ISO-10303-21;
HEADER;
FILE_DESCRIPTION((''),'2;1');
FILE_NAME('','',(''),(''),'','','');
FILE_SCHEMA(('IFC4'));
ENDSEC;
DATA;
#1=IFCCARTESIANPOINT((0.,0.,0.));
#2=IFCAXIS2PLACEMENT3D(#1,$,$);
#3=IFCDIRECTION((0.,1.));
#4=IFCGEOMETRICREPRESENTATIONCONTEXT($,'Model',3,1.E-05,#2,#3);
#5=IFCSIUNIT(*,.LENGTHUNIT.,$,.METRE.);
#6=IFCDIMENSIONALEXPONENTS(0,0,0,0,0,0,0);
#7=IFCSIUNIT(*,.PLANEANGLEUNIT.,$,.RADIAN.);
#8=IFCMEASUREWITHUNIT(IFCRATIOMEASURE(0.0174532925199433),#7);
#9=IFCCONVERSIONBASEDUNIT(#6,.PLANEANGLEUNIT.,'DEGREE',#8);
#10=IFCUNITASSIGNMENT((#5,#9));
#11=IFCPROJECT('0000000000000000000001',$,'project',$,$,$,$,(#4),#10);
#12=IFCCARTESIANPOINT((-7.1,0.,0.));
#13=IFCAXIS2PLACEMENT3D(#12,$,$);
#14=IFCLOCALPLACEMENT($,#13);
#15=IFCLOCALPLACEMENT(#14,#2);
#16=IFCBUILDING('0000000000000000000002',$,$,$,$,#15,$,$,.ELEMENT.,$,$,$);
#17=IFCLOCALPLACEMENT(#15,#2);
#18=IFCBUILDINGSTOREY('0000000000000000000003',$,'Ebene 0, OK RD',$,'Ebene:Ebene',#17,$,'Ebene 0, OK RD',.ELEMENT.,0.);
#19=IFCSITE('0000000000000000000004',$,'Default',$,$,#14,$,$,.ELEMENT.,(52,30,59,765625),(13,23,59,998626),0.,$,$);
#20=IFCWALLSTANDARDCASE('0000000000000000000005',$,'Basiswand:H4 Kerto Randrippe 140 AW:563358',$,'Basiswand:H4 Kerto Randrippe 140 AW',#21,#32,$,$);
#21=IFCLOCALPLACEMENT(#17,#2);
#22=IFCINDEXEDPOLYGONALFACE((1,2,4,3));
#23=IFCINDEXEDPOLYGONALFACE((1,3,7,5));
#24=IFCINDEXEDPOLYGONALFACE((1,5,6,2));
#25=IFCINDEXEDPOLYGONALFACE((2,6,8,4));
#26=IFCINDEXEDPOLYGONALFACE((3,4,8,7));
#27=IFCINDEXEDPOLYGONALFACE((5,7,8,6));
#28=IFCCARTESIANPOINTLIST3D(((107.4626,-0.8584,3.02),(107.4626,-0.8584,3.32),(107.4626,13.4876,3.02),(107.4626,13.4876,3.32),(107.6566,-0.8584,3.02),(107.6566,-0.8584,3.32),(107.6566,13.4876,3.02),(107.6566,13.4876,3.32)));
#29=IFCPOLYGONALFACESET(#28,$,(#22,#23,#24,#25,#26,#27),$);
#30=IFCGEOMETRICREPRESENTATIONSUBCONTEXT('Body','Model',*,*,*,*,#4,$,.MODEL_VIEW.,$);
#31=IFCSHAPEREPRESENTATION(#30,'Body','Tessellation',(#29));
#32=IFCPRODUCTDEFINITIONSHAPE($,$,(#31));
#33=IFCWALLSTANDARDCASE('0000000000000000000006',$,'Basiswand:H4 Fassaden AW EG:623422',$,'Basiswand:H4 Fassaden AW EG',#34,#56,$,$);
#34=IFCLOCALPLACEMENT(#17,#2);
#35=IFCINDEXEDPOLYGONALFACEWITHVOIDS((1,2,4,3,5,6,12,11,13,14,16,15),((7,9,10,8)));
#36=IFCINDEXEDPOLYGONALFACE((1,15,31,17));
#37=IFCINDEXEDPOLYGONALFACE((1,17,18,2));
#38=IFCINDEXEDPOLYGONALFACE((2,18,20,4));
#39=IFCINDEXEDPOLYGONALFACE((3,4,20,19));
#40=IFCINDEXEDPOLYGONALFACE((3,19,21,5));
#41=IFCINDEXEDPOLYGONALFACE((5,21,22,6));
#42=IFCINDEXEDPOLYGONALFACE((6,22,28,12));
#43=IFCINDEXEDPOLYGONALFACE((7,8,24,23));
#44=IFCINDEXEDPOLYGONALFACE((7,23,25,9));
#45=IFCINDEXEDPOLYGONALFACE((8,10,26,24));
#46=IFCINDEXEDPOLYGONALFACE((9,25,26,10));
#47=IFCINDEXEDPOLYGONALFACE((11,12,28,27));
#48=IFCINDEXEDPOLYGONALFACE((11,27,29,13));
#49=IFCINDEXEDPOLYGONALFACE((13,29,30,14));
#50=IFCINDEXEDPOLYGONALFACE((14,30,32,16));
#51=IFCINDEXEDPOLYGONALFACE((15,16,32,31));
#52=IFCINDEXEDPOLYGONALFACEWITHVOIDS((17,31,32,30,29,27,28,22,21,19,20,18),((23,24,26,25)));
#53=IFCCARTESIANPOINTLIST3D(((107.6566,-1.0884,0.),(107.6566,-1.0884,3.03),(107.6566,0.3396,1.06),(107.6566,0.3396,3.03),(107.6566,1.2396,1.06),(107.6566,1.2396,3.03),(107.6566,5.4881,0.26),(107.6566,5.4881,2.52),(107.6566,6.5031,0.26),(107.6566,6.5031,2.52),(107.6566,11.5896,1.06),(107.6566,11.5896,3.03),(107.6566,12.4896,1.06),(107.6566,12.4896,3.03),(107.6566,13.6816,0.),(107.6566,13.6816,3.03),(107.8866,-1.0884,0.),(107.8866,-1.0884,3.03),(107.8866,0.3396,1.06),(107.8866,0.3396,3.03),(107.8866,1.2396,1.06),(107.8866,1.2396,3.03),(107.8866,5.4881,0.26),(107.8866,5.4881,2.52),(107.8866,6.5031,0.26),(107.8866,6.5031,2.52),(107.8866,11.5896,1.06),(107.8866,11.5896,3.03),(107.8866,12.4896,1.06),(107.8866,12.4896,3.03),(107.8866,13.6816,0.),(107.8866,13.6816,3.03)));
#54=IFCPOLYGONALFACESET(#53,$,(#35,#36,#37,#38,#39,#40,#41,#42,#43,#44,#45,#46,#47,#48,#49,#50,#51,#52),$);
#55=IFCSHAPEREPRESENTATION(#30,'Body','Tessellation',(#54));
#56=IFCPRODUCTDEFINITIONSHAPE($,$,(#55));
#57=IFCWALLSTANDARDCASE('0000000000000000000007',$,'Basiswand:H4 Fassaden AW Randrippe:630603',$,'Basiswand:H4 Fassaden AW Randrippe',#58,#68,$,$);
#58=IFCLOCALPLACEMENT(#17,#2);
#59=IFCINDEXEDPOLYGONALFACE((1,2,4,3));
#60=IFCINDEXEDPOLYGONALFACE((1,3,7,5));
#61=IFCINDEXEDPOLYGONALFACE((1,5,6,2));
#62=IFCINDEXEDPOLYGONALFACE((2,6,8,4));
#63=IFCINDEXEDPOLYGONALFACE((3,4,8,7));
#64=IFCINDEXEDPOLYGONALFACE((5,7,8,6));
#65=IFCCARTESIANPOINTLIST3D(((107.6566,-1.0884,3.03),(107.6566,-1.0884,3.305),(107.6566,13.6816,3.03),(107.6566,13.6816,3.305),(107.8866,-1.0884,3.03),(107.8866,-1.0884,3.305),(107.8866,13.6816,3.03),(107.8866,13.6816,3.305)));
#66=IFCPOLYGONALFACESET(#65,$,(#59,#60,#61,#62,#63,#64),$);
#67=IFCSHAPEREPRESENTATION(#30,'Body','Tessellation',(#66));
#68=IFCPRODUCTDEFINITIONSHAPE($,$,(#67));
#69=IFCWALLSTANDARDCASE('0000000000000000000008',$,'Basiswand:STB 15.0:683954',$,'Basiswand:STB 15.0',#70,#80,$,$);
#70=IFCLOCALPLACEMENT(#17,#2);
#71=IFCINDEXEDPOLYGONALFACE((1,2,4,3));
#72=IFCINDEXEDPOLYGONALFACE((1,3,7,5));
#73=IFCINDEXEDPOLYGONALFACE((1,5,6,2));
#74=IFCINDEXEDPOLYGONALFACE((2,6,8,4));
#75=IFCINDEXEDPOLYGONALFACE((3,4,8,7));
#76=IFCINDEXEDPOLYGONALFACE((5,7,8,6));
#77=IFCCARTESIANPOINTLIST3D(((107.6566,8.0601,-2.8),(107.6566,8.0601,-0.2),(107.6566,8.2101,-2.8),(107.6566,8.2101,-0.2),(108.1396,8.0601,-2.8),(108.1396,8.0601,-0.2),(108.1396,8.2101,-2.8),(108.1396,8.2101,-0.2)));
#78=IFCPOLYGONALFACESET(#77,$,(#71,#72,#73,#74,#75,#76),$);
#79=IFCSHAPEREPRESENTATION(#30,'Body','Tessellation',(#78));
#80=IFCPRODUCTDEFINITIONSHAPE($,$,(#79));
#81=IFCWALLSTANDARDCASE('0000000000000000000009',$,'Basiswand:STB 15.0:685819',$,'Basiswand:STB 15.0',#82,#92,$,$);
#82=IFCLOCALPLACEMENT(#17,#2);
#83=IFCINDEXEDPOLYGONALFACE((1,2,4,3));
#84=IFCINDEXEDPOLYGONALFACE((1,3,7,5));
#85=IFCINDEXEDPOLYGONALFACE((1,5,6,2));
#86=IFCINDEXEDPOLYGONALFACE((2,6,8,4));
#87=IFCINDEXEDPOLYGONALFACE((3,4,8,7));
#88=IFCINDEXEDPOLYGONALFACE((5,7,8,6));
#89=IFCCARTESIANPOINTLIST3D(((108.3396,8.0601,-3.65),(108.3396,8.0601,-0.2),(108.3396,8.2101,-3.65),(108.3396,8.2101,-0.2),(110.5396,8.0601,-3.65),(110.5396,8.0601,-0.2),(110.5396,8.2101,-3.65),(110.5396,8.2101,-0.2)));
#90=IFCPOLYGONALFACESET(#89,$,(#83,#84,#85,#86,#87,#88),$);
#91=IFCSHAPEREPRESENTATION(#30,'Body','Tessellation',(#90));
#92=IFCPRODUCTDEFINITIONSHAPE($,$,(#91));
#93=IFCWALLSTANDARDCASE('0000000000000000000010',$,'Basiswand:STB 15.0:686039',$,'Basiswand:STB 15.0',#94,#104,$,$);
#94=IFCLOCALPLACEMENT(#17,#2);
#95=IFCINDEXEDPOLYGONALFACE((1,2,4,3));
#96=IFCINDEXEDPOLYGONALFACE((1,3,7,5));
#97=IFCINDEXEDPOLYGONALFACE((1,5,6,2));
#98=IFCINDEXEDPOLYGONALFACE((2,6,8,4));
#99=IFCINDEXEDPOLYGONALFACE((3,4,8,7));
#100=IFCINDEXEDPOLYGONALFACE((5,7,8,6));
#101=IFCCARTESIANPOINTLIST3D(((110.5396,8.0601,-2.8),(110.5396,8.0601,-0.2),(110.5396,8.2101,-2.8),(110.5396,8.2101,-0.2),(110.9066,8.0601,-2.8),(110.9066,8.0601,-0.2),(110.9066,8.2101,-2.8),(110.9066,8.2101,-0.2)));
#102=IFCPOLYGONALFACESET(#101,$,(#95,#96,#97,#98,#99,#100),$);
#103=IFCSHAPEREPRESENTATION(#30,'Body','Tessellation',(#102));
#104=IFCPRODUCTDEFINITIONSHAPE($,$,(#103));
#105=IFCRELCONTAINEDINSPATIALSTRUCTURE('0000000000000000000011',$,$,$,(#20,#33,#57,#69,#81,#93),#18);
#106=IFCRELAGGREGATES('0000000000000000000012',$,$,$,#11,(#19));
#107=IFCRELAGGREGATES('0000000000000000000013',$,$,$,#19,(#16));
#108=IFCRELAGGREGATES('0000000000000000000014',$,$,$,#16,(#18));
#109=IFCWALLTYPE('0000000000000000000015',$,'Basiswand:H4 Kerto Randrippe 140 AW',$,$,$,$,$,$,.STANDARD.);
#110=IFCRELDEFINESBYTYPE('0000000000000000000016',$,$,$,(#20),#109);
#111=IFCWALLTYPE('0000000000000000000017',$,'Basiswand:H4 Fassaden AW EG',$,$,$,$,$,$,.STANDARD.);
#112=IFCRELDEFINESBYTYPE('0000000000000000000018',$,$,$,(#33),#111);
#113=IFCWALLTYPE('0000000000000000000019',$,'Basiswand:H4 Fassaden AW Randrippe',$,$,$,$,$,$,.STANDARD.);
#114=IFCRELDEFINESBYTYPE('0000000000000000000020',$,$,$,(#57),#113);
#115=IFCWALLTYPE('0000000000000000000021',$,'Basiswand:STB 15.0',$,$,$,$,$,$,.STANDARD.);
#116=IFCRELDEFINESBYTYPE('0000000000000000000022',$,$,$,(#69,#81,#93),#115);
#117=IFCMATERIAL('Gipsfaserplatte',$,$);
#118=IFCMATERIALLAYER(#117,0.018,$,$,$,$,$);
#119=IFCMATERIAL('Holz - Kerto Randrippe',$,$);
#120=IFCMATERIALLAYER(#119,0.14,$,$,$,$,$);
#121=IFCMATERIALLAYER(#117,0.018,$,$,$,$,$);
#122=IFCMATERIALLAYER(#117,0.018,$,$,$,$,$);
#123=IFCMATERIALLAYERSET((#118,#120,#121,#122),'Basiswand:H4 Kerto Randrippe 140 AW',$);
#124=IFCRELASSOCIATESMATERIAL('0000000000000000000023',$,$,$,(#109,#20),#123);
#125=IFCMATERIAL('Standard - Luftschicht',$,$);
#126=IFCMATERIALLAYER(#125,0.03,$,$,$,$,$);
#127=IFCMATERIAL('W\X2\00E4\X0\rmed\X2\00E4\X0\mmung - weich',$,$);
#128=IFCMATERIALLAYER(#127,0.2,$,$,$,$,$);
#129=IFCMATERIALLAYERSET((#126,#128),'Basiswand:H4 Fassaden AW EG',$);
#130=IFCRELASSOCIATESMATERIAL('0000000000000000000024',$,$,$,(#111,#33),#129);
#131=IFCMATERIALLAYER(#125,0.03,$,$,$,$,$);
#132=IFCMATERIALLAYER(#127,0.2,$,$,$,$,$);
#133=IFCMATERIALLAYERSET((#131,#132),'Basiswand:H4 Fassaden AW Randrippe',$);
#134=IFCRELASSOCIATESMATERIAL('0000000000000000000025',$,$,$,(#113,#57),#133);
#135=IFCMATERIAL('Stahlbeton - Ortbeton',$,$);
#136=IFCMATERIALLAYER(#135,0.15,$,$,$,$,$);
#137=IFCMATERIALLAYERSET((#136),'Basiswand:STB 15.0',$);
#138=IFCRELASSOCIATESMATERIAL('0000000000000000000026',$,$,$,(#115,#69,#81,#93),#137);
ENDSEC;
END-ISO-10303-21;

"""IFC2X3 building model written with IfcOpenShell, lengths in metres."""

from ifc_helpers import new_model, entity, si_unit, converted_unit, direction, frame, frame_2d, origin, place, context, subcontext, project, spatial, rectangle, extrude, material, layer, layer_set, layer_usage, type_object, element, save


model = new_model("IFC2X3")

# Units and contexts
model_context = context("Model", 3, precision=1e-05, world=origin(), true_north=direction((0.0, 1.0)))
body_context = subcontext(model_context, "Body", "Model", "MODEL_VIEW")
ifc_project = project(units=[si_unit("LENGTHUNIT", "METRE"), converted_unit("PLANEANGLEUNIT", "DEGREE", entity("IfcRatioMeasure", 0.0174532925199433), si_unit("PLANEANGLEUNIT", "RADIAN"), dimensions=[0, 0, 0, 0, 0, 0, 0])], contexts=[model_context])

# Site, building, storey
site_placement = place(None, frame((-7.1, 0.0, 0.0)))
site = spatial("IfcSite", under=ifc_project, at=site_placement, Name="Default", CompositionType="ELEMENT", RefLatitude=(52, 30, 59, 765625), RefLongitude=(13, 23, 59, 998626), RefElevation=0.0)
building_placement = place(site_placement, origin())
building = spatial("IfcBuilding", under=site, at=building_placement, CompositionType="ELEMENT")
storey_placement = place(building_placement, origin())
storey = spatial("IfcBuildingStorey", under=building, at=storey_placement, Name="Ebene 0, OK RD", ObjectType="Ebene:Ebene", LongName="Ebene 0, OK RD", CompositionType="ELEMENT", Elevation=0.0)

# Shared definitions
ifc_material_1 = material(Name="Gipsfaserplatte")

# Shared definitions
ifc_material_2 = material(Name="Stahlbeton - Ortbeton")

# Wall
ifc_layer_1 = layer(ifc_material_1, 0.018)
ifc_material_3 = material(Name="Holz - Kerto Randrippe")
ifc_layer_2 = layer(ifc_material_3, 0.14)
ifc_layer_3 = layer(ifc_material_1, 0.018)
ifc_layer_4 = layer(ifc_material_1, 0.018)
ifc_layer_set_1 = layer_set([ifc_layer_1, ifc_layer_2, ifc_layer_3, ifc_layer_4], Name="Basiswand:H4 Kerto Randrippe 140 AW")
ifc_layer_usage_1 = layer_usage(ifc_layer_set_1, "AXIS2", "NEGATIVE", 0.097)
wall_type_1 = type_object("IfcWallType", Name="Basiswand:H4 Kerto Randrippe 140 AW", PredefinedType="STANDARD", material=ifc_layer_set_1)
wall_1_placement = place(storey_placement, frame((107.5596, 13.4876, 3.02), z_axis=(0.0, 0.0, 1.0), x_axis=(0.0, -1.0, 0.0)))
element("IfcWallStandardCase", 1, at=wall_1_placement, inside=storey, type_object=wall_type_1, material=ifc_layer_usage_1, Name="Basiswand:H4 Kerto Randrippe 140 AW:563358", ObjectType="Basiswand:H4 Kerto Randrippe 140 AW", context=body_context, shape_type="SweptSolid", body=[
    extrude(rectangle(XDim=14.346, YDim=0.194, at=frame_2d((7.173, 0.0), x_axis=(-1.0, 0.0))), origin(), (0.0, 0.0, 1.0), 0.3),
])

# Wall, openings
ifc_material_4 = material(Name="Standard - Luftschicht")
ifc_layer_5 = layer(ifc_material_4, 0.03)
ifc_material_5 = material(Name="Wärmedämmung - weich")
ifc_layer_6 = layer(ifc_material_5, 0.2)
ifc_layer_set_2 = layer_set([ifc_layer_5, ifc_layer_6], Name="Basiswand:H4 Fassaden AW EG")
ifc_layer_usage_2 = layer_usage(ifc_layer_set_2, "AXIS2", "NEGATIVE", 0.115)
wall_type_2 = type_object("IfcWallType", Name="Basiswand:H4 Fassaden AW EG", PredefinedType="STANDARD", material=ifc_layer_set_2)
wall_2_placement = place(storey_placement, frame((107.7716, 13.6816, 0.0), z_axis=(0.0, 0.0, 1.0), x_axis=(0.0, -1.0, 0.0)))
wall_2 = element("IfcWallStandardCase", 2, at=wall_2_placement, inside=storey, type_object=wall_type_2, material=ifc_layer_usage_2, Name="Basiswand:H4 Fassaden AW EG:623422", ObjectType="Basiswand:H4 Fassaden AW EG", context=body_context, shape_type="SweptSolid", body=[
    extrude(rectangle(XDim=14.77, YDim=0.23, at=frame_2d((7.385, 0.0), x_axis=(-1.0, 0.0))), origin(), (0.0, 0.0, 1.0), 3.03),
])
opening_1_placement = place(wall_2_placement, frame((2.092, 0.115, 1.06)))
element("IfcOpeningElement", 3, at=opening_1_placement, cuts=wall_2, ObjectType="Opening", context=body_context, shape_type="SweptSolid", body=[
    extrude(rectangle(XDim=1.97, YDim=0.9, at=frame_2d((0.985, 0.45), x_axis=(1.0, 0.0))), frame((0.0, 0.0, 0.0), z_axis=(0.0, -1.0, 0.0), x_axis=(0.0, 0.0, 1.0)), (0.0, 0.0, 1.0), 0.23),
])
opening_2_placement = place(wall_2_placement, frame((13.342, 0.115, 1.06)))
element("IfcOpeningElement", 4, at=opening_2_placement, cuts=wall_2, ObjectType="Opening", context=body_context, shape_type="SweptSolid", body=[
    extrude(rectangle(XDim=1.97, YDim=0.9, at=frame_2d((0.985, 0.45), x_axis=(1.0, 0.0))), frame((0.0, 0.0, 0.0), z_axis=(0.0, -1.0, 0.0), x_axis=(0.0, 0.0, 1.0)), (0.0, 0.0, 1.0), 0.23),
])
opening_3_placement = place(wall_2_placement, frame((8.1935, 0.115, 0.26)))
element("IfcOpeningElement", 5, at=opening_3_placement, cuts=wall_2, ObjectType="Opening", context=body_context, shape_type="SweptSolid", body=[
    extrude(rectangle(XDim=2.26, YDim=1.015, at=frame_2d((1.13, 0.5075), x_axis=(1.0, 0.0))), frame((0.0, 0.0, 0.0), z_axis=(0.0, -1.0, 0.0), x_axis=(0.0, 0.0, 1.0)), (0.0, 0.0, 1.0), 0.23),
])

# Walls
ifc_layer_7 = layer(ifc_material_4, 0.03)
ifc_layer_8 = layer(ifc_material_5, 0.2)
ifc_layer_set_3 = layer_set([ifc_layer_7, ifc_layer_8], Name="Basiswand:H4 Fassaden AW Randrippe")
ifc_layer_usage_3 = layer_usage(ifc_layer_set_3, "AXIS2", "NEGATIVE", 0.115)
wall_type_3 = type_object("IfcWallType", Name="Basiswand:H4 Fassaden AW Randrippe", PredefinedType="STANDARD", material=ifc_layer_set_3)
wall_3_placement = place(storey_placement, frame((107.7716, 13.6816, 3.03), z_axis=(0.0, 0.0, 1.0), x_axis=(0.0, -1.0, 0.0)))
element("IfcWallStandardCase", 6, at=wall_3_placement, inside=storey, type_object=wall_type_3, material=ifc_layer_usage_3, Name="Basiswand:H4 Fassaden AW Randrippe:630603", ObjectType="Basiswand:H4 Fassaden AW Randrippe", context=body_context, shape_type="SweptSolid", body=[
    extrude(rectangle(XDim=14.77, YDim=0.23, at=frame_2d((7.385, 0.0), x_axis=(-1.0, 0.0))), origin(), (0.0, 0.0, 1.0), 0.275),
])
ifc_layer_9 = layer(ifc_material_2, 0.15)
ifc_layer_set_4 = layer_set([ifc_layer_9], Name="Basiswand:STB 15.0")
ifc_layer_usage_4 = layer_usage(ifc_layer_set_4, "AXIS2", "NEGATIVE", 0.075)
wall_type_4 = type_object("IfcWallType", Name="Basiswand:STB 15.0", PredefinedType="STANDARD", material=ifc_layer_set_4)
wall_4_placement = place(storey_placement, frame((107.6566, 8.1351, -2.8)))
element("IfcWallStandardCase", 7, at=wall_4_placement, inside=storey, type_object=wall_type_4, material=ifc_layer_usage_4, Name="Basiswand:STB 15.0:683954", ObjectType="Basiswand:STB 15.0", context=body_context, shape_type="SweptSolid", body=[
    extrude(rectangle(XDim=0.483, YDim=0.15, at=frame_2d((0.2415, 0.0), x_axis=(-1.0, 0.0))), origin(), (0.0, 0.0, 1.0), 2.6),
])
ifc_layer_usage_5 = layer_usage(ifc_layer_set_4, "AXIS2", "NEGATIVE", 0.075)
wall_5_placement = place(storey_placement, frame((108.3396, 8.1351, -3.65)))
element("IfcWallStandardCase", 8, at=wall_5_placement, inside=storey, type_object=wall_type_4, material=ifc_layer_usage_5, Name="Basiswand:STB 15.0:685819", ObjectType="Basiswand:STB 15.0", context=body_context, shape_type="SweptSolid", body=[
    extrude(rectangle(XDim=2.2, YDim=0.15, at=frame_2d((1.1, 0.0), x_axis=(-1.0, 0.0))), origin(), (0.0, 0.0, 1.0), 3.45),
])
ifc_layer_usage_6 = layer_usage(ifc_layer_set_4, "AXIS2", "NEGATIVE", 0.075)
wall_6_placement = place(storey_placement, frame((110.5396, 8.1351, -2.8)))
element("IfcWallStandardCase", 9, at=wall_6_placement, inside=storey, type_object=wall_type_4, material=ifc_layer_usage_6, Name="Basiswand:STB 15.0:686039", ObjectType="Basiswand:STB 15.0", context=body_context, shape_type="SweptSolid", body=[
    extrude(rectangle(XDim=0.367, YDim=0.15, at=frame_2d((0.1835, 0.0), x_axis=(-1.0, 0.0))), origin(), (0.0, 0.0, 1.0), 2.6),
])

save(model, "model.ifc")
